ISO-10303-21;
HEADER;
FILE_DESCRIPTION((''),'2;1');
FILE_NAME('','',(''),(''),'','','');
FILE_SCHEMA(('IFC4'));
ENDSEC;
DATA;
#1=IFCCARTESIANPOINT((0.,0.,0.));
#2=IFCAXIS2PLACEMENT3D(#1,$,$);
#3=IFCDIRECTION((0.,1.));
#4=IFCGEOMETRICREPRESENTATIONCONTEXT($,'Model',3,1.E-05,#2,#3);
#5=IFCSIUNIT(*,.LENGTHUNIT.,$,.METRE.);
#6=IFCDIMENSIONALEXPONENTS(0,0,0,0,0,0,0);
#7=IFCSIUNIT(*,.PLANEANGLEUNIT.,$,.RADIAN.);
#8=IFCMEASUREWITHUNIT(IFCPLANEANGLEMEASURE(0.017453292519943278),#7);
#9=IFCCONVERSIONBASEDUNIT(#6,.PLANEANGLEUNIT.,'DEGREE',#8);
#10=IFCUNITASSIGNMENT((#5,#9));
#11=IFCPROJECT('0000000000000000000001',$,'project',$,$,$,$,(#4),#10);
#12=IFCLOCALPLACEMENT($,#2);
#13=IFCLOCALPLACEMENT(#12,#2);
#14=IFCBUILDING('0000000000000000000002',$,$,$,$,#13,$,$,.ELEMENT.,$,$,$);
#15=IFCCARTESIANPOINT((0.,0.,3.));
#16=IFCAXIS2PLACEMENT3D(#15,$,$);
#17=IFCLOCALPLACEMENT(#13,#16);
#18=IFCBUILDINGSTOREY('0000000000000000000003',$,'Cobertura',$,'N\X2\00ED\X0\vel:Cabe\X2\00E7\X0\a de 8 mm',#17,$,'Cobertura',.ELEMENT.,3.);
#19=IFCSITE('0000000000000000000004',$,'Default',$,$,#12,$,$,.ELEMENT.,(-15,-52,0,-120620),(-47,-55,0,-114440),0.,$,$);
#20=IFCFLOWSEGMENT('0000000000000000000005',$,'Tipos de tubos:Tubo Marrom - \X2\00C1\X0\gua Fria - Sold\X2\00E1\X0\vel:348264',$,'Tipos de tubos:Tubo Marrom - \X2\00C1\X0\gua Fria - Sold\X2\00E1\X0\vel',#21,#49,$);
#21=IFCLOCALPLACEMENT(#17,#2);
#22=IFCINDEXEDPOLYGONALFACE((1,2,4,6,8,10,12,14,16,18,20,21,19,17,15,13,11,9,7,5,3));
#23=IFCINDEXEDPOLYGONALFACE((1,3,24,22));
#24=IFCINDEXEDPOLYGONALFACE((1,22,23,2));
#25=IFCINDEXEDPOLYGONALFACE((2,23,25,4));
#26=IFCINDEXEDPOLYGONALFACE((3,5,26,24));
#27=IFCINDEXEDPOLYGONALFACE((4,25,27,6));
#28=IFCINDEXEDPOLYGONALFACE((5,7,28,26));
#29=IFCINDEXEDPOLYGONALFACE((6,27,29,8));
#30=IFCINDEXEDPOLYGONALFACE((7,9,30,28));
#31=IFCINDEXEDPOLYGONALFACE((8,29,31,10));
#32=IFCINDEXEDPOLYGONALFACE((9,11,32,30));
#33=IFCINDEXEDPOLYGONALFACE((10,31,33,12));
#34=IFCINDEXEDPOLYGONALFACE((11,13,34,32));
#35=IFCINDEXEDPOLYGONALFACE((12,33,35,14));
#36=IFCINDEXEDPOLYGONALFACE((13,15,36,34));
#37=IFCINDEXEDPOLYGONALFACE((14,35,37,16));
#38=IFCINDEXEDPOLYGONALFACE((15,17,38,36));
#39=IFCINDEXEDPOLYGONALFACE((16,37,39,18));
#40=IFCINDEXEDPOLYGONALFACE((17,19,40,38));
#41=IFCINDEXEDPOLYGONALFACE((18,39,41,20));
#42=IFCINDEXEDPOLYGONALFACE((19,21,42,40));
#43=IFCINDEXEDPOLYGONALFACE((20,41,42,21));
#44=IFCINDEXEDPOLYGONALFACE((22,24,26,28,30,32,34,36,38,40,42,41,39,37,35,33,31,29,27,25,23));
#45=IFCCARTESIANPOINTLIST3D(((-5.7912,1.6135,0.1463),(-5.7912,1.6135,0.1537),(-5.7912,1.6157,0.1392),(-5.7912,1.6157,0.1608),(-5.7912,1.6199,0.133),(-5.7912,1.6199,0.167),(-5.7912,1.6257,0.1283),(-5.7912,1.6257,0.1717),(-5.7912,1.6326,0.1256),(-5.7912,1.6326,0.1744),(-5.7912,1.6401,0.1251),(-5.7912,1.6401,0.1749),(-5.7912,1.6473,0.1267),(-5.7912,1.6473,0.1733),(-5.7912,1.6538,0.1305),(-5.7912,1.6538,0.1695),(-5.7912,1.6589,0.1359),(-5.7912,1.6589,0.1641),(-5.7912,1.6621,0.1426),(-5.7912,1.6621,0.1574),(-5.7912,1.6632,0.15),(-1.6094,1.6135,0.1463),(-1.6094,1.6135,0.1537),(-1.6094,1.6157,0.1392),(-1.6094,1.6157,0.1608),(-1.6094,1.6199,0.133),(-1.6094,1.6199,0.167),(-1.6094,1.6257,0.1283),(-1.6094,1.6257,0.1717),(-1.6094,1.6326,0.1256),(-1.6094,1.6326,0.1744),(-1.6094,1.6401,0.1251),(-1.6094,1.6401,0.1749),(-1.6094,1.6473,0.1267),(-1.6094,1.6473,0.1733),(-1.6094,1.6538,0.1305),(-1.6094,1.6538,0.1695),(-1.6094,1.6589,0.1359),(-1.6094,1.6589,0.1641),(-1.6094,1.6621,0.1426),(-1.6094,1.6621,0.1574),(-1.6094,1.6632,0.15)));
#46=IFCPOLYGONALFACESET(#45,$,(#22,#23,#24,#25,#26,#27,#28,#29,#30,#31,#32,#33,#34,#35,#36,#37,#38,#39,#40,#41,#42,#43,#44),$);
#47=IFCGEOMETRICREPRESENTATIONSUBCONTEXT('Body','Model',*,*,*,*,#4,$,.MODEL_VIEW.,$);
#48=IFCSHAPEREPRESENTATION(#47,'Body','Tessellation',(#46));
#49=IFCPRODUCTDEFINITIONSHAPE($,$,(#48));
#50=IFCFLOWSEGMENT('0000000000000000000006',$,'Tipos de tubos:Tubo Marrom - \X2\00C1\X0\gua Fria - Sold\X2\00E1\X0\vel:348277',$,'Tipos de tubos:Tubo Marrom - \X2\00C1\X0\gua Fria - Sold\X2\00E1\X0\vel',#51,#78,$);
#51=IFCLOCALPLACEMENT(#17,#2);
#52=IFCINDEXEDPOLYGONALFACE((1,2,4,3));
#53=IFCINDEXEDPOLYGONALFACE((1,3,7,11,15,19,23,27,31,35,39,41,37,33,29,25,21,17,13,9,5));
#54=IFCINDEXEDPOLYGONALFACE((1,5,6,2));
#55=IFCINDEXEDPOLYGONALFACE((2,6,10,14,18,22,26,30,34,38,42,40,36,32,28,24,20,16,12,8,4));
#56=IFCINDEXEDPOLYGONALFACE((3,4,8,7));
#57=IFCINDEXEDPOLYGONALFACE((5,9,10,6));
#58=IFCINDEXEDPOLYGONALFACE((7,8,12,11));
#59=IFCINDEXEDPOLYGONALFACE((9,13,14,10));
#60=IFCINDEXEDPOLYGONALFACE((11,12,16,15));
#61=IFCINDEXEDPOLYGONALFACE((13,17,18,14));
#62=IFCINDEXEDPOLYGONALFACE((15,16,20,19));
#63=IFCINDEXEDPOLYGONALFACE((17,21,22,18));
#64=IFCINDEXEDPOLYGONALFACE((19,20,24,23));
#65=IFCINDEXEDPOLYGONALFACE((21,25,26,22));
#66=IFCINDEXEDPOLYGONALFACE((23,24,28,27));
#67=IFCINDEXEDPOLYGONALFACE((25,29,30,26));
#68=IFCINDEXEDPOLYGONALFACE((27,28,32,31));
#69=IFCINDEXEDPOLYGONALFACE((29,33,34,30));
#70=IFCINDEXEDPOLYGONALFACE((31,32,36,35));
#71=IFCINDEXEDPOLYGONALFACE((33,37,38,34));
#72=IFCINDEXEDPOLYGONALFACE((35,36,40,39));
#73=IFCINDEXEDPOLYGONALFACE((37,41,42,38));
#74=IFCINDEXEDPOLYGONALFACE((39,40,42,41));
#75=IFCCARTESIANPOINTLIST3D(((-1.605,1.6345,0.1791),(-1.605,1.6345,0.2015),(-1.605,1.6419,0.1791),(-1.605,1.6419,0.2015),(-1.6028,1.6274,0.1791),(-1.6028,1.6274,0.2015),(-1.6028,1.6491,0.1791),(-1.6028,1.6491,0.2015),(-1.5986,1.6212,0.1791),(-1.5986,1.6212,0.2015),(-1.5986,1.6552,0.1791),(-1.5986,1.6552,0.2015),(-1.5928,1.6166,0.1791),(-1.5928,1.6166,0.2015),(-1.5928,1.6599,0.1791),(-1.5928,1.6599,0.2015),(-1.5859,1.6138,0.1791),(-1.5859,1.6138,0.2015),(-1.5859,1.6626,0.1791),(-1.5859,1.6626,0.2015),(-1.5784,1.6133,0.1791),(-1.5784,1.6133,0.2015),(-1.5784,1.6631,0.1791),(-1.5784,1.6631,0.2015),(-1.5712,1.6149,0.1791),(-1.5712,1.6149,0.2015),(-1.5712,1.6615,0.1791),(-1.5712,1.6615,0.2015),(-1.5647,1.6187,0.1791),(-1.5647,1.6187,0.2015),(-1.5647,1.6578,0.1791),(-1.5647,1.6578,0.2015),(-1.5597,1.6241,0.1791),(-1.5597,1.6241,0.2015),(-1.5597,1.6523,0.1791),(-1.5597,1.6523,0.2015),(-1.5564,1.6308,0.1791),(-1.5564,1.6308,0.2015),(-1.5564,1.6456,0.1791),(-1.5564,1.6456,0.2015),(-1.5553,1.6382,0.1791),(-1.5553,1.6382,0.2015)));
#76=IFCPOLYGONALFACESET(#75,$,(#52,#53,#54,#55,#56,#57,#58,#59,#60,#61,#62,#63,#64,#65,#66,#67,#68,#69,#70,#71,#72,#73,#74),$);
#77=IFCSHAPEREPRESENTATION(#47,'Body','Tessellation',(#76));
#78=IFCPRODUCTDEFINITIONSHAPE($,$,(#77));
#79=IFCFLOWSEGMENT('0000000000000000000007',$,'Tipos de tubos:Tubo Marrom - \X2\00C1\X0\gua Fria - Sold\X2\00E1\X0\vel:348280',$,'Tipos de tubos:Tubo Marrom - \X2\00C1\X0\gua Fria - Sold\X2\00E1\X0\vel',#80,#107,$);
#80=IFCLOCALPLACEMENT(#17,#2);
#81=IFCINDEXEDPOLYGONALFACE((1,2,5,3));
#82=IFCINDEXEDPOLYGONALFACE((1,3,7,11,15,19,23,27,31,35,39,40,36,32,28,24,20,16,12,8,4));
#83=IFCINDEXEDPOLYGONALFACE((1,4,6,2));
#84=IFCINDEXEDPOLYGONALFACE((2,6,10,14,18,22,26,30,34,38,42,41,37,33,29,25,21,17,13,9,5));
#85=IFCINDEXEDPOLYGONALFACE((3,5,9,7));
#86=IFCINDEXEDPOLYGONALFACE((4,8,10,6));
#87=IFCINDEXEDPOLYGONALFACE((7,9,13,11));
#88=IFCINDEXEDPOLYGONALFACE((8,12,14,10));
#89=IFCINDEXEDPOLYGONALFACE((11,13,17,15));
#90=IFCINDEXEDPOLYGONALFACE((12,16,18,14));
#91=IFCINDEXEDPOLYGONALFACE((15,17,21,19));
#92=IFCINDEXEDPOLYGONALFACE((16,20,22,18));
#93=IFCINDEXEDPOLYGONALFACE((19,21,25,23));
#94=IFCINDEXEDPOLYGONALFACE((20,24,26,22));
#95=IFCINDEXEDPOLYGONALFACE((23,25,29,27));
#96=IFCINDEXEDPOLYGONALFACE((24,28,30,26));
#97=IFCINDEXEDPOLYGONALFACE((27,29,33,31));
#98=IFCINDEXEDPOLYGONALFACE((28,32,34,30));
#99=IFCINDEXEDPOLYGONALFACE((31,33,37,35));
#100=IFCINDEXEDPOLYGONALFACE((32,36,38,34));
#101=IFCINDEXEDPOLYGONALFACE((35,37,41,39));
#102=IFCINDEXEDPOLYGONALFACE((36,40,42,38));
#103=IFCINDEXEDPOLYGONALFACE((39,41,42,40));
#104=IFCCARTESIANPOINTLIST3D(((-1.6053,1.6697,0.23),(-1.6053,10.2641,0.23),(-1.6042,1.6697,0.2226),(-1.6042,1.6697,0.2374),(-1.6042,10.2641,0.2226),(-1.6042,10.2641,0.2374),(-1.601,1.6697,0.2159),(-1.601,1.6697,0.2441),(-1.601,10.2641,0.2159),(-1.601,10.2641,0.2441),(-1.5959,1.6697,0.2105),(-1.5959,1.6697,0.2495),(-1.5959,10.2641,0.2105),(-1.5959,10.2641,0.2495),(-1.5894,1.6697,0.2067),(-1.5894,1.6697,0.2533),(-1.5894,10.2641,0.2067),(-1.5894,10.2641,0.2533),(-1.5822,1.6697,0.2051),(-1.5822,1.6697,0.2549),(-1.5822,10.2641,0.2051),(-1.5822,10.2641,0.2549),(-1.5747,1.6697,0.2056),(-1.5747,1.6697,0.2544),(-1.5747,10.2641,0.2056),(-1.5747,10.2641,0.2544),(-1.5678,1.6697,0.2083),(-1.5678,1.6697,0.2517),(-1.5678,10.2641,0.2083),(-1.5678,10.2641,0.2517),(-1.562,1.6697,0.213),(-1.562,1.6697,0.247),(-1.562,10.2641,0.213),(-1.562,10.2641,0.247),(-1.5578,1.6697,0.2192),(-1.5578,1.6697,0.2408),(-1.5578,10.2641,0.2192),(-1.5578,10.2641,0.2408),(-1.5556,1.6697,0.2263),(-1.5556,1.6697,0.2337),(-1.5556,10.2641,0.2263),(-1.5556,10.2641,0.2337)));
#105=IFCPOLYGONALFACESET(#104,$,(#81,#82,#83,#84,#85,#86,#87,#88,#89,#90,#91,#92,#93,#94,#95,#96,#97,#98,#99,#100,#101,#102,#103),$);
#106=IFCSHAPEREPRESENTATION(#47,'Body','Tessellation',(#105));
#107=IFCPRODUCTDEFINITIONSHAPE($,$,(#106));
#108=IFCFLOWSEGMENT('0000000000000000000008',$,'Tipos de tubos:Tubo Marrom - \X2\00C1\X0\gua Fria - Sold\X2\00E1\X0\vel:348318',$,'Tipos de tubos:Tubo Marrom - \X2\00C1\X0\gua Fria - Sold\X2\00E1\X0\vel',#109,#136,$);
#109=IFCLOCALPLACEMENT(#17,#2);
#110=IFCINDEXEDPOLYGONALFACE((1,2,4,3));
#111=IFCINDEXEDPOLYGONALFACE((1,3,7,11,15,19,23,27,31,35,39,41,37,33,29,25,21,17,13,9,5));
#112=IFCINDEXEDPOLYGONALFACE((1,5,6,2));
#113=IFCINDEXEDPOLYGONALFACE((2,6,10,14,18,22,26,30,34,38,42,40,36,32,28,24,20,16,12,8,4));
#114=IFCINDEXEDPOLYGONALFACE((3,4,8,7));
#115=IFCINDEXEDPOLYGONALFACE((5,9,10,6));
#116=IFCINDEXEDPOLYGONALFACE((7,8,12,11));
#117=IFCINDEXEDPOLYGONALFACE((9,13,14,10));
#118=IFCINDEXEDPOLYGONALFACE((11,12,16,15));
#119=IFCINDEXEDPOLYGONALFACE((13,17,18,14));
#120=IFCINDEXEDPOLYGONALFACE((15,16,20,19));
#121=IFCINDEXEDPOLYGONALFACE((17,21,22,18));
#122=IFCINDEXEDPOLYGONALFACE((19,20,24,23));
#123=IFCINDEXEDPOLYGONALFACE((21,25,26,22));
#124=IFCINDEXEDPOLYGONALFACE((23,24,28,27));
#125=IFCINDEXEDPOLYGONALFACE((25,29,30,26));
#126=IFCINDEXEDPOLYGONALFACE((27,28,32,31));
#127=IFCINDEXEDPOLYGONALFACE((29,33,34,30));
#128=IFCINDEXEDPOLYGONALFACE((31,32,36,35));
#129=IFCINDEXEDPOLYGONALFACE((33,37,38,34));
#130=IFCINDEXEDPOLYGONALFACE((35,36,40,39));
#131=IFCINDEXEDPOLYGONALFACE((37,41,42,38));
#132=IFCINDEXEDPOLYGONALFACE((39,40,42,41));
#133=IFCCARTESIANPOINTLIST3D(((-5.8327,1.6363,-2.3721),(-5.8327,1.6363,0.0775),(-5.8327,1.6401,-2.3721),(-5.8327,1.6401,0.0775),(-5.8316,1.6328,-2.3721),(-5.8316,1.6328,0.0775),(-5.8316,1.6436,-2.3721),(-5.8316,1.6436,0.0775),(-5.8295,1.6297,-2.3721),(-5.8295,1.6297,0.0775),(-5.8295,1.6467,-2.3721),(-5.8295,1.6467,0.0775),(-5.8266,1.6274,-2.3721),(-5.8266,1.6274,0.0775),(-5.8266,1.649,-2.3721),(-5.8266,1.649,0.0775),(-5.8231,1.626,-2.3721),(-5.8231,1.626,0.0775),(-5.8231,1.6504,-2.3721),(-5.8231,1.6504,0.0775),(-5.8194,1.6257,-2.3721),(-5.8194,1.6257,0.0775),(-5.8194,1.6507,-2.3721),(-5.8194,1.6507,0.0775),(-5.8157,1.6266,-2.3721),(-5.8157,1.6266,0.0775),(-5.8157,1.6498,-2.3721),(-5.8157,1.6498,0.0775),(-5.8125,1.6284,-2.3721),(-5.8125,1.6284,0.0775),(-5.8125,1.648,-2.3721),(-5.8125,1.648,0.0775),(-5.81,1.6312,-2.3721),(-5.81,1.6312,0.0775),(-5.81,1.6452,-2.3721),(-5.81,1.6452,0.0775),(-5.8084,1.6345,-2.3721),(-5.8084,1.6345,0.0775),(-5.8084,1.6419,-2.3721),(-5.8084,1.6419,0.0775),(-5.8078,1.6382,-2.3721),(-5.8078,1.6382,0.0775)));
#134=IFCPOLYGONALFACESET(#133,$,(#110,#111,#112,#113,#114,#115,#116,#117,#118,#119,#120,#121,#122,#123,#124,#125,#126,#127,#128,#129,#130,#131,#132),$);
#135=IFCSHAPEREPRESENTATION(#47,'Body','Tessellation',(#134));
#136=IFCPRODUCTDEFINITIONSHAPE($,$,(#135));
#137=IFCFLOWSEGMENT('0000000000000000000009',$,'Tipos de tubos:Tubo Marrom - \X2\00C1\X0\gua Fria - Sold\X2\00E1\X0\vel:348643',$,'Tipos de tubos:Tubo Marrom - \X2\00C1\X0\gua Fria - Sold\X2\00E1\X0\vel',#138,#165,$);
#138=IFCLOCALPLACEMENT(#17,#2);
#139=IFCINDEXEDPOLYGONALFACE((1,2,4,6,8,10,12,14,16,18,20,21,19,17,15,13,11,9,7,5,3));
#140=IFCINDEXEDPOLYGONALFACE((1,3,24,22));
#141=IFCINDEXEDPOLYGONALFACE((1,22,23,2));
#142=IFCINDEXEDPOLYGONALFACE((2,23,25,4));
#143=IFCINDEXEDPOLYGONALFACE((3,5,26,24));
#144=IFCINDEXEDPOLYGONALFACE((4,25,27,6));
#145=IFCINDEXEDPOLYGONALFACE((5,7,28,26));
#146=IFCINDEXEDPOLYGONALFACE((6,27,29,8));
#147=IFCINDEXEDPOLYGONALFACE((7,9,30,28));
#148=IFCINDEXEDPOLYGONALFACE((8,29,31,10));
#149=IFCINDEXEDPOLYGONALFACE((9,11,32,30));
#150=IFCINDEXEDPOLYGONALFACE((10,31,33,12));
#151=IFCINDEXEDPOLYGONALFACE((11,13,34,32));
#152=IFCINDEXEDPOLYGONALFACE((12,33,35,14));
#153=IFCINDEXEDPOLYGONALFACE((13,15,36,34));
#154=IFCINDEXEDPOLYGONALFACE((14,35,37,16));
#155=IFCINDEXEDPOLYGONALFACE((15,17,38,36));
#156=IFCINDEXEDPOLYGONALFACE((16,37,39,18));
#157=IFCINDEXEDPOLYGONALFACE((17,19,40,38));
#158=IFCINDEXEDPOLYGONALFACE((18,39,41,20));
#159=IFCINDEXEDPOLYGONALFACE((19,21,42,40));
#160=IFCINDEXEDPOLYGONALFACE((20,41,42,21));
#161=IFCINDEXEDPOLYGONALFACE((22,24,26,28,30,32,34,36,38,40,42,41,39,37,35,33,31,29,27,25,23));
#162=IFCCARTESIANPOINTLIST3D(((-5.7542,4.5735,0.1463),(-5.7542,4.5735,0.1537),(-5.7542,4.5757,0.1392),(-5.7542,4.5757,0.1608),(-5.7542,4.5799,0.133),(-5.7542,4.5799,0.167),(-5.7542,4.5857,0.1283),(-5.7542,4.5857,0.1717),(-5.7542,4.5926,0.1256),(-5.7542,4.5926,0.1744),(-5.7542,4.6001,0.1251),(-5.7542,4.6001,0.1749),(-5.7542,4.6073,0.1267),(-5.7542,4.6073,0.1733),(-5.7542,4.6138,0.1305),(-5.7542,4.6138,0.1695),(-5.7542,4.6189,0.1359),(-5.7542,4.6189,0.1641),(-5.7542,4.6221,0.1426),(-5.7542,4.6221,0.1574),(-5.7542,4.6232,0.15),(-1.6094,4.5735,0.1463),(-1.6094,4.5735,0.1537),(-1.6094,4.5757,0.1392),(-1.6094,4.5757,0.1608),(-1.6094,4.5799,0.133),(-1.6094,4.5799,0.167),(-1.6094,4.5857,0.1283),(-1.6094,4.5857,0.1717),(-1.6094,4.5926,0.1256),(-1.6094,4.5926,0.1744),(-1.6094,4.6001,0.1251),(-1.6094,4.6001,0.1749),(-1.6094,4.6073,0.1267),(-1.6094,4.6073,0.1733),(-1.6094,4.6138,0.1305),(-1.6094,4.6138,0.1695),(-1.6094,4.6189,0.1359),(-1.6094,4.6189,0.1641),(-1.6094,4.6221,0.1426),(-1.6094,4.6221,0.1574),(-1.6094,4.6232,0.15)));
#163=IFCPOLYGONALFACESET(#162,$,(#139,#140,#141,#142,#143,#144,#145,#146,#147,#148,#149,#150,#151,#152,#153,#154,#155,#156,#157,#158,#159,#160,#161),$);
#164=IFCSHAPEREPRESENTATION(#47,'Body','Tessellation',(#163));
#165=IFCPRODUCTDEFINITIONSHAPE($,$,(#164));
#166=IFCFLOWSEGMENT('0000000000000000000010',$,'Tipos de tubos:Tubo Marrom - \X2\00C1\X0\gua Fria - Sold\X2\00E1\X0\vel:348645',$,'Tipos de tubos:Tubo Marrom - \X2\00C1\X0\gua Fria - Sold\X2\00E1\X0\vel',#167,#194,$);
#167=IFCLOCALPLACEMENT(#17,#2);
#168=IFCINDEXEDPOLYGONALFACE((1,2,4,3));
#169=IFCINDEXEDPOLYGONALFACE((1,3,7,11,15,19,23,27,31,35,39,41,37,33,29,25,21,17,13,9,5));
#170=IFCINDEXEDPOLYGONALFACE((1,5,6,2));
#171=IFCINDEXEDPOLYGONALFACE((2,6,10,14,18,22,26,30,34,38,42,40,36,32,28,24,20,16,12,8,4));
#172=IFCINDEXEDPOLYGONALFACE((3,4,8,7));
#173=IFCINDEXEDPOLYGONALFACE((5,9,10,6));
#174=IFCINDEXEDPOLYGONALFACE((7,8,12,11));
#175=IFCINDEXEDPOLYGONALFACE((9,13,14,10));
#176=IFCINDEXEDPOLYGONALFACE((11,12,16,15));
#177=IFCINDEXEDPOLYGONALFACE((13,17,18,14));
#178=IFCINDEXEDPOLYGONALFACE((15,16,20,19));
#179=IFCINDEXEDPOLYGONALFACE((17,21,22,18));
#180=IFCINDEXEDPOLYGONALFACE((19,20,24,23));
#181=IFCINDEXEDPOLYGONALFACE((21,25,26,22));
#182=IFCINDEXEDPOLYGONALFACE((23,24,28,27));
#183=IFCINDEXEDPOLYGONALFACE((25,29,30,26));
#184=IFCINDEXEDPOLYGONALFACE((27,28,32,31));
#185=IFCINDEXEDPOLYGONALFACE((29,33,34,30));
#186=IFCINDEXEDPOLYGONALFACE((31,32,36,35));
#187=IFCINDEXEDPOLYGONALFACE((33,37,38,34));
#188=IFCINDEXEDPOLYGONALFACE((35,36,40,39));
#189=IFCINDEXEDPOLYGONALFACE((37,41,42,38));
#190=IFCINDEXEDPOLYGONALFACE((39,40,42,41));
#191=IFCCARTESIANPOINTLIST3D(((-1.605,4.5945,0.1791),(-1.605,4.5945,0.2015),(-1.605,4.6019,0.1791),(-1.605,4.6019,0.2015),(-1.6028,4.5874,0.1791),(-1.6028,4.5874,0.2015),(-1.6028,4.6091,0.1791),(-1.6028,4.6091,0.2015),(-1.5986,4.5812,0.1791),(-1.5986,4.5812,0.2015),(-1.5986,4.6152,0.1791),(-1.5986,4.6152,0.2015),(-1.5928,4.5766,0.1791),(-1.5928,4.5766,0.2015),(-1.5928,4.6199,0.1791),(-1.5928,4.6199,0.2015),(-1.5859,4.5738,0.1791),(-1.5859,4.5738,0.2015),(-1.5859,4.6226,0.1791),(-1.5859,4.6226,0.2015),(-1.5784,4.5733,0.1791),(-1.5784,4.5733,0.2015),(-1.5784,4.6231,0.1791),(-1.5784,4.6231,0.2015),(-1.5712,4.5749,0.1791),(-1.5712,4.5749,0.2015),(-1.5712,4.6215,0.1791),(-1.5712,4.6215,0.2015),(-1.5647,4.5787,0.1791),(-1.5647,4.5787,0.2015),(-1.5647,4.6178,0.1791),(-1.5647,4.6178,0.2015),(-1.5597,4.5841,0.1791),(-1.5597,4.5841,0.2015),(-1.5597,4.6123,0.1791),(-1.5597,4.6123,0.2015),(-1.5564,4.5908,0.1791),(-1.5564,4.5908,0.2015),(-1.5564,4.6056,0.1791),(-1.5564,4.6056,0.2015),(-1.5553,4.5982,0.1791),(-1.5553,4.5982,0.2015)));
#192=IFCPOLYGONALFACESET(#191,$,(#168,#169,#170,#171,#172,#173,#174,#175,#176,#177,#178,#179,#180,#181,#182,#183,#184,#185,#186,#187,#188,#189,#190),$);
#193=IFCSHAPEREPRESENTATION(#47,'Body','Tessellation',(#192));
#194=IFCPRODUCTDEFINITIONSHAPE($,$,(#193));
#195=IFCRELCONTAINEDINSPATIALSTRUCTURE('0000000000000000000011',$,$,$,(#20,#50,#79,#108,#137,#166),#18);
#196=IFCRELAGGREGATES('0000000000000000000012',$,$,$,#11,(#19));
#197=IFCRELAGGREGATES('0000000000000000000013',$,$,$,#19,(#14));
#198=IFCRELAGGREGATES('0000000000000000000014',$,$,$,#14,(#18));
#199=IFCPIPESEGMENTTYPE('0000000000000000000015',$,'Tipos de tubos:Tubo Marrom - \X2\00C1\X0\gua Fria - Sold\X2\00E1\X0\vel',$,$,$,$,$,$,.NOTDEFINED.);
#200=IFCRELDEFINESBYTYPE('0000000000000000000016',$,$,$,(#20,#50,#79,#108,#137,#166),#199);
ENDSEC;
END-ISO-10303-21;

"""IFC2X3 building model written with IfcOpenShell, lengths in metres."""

from ifc_helpers import new_model, entity, si_unit, converted_unit, direction, frame, frame_2d, origin, origin_2d_with_axis, place, context, subcontext, project, spatial, circle, extrude, type_object, element, save


model = new_model("IFC2X3")

# Units and contexts
model_context = context("Model", 3, precision=1e-05, world=origin(), true_north=direction((0.0, 1.0)))
body_context = subcontext(model_context, "Body", "Model", "MODEL_VIEW")
ifc_project = project(units=[si_unit("LENGTHUNIT", "METRE"), converted_unit("PLANEANGLEUNIT", "DEGREE", entity("IfcPlaneAngleMeasure", 0.017453292519943278), si_unit("PLANEANGLEUNIT", "RADIAN"), dimensions=[0, 0, 0, 0, 0, 0, 0])], contexts=[model_context])

# Site, building, storey
site_placement = place(None, origin())
site = spatial("IfcSite", under=ifc_project, at=site_placement, Name="Default", CompositionType="ELEMENT", RefLatitude=(-15, -52, 0, -120620), RefLongitude=(-47, -55, 0, -114440), RefElevation=0.0)
building_placement = place(site_placement, origin())
building = spatial("IfcBuilding", under=site, at=building_placement, CompositionType="ELEMENT")
storey_placement = place(building_placement, frame((0.0, 0.0, 3.0)))
storey = spatial("IfcBuildingStorey", under=building, at=storey_placement, Name="Cobertura", ObjectType="Nível:Cabeça de 8 mm", LongName="Cobertura", CompositionType="ELEMENT", Elevation=3.0)

# Flow segments
pipe_segment_type = type_object("IfcPipeSegmentType", Name="Tipos de tubos:Tubo Marrom - Água Fria - Soldável", PredefinedType="NOTDEFINED")
flow_segment_1_placement = place(storey_placement, origin())
element("IfcFlowSegment", 1, at=flow_segment_1_placement, inside=storey, type_object=pipe_segment_type, Name="Tipos de tubos:Tubo Marrom - Água Fria - Soldável:348264", ObjectType="Tipos de tubos:Tubo Marrom - Água Fria - Soldável", context=body_context, shape_type="SweptSolid", body=[
    extrude(circle(Radius=0.025, at=frame_2d((0.0, 0.0), x_axis=(1.0, 0.0))), frame((-5.7912, 1.6382, 0.15), z_axis=(1.0, 0.0, 0.0), x_axis=(0.0, 1.0, 0.0)), (0.0, 0.0, 1.0), 4.1818),
])
flow_segment_2_placement = place(storey_placement, origin())
element("IfcFlowSegment", 2, at=flow_segment_2_placement, inside=storey, type_object=pipe_segment_type, Name="Tipos de tubos:Tubo Marrom - Água Fria - Soldável:348277", ObjectType="Tipos de tubos:Tubo Marrom - Água Fria - Soldável", context=body_context, shape_type="SweptSolid", body=[
    extrude(circle(Radius=0.025, at=frame_2d((0.0, 0.0), x_axis=(1.0, 0.0))), frame((-1.5803, 1.6382, 0.1791)), (0.0, 0.0, 1.0), 0.0224),
])
flow_segment_3_placement = place(storey_placement, origin())
element("IfcFlowSegment", 3, at=flow_segment_3_placement, inside=storey, type_object=pipe_segment_type, Name="Tipos de tubos:Tubo Marrom - Água Fria - Soldável:348280", ObjectType="Tipos de tubos:Tubo Marrom - Água Fria - Soldável", context=body_context, shape_type="SweptSolid", body=[
    extrude(circle(Radius=0.025, at=frame_2d((0.0, 0.0), x_axis=(1.0, 0.0))), frame((-1.5803, 1.6697, 0.23), z_axis=(0.0, 1.0, 0.0), x_axis=(-1.0, 0.0, 0.0)), (0.0, 0.0, 1.0), 8.5944),
])
flow_segment_4_placement = place(storey_placement, origin())
element("IfcFlowSegment", 4, at=flow_segment_4_placement, inside=storey, type_object=pipe_segment_type, Name="Tipos de tubos:Tubo Marrom - Água Fria - Soldável:348318", ObjectType="Tipos de tubos:Tubo Marrom - Água Fria - Soldável", context=body_context, shape_type="SweptSolid", body=[
    extrude(circle(Radius=0.0125, at=origin_2d_with_axis()), frame((-5.8203, 1.6382, -2.3721)), (0.0, 0.0, 1.0), 2.4496),
])
flow_segment_5_placement = place(storey_placement, origin())
element("IfcFlowSegment", 5, at=flow_segment_5_placement, inside=storey, type_object=pipe_segment_type, Name="Tipos de tubos:Tubo Marrom - Água Fria - Soldável:348643", ObjectType="Tipos de tubos:Tubo Marrom - Água Fria - Soldável", context=body_context, shape_type="SweptSolid", body=[
    extrude(circle(Radius=0.025, at=origin_2d_with_axis()), frame((-5.7542, 4.5982, 0.15), z_axis=(1.0, 0.0, 0.0), x_axis=(0.0, 1.0, 0.0)), (0.0, 0.0, 1.0), 4.1448),
])
flow_segment_6_placement = place(storey_placement, origin())
element("IfcFlowSegment", 6, at=flow_segment_6_placement, inside=storey, type_object=pipe_segment_type, Name="Tipos de tubos:Tubo Marrom - Água Fria - Soldável:348645", ObjectType="Tipos de tubos:Tubo Marrom - Água Fria - Soldável", context=body_context, shape_type="SweptSolid", body=[
    extrude(circle(Radius=0.025, at=frame_2d((0.0, 0.0), x_axis=(1.0, 0.0))), frame((-1.5803, 4.5982, 0.1791)), (0.0, 0.0, 1.0), 0.0224),
])

save(model, "model.ifc")
